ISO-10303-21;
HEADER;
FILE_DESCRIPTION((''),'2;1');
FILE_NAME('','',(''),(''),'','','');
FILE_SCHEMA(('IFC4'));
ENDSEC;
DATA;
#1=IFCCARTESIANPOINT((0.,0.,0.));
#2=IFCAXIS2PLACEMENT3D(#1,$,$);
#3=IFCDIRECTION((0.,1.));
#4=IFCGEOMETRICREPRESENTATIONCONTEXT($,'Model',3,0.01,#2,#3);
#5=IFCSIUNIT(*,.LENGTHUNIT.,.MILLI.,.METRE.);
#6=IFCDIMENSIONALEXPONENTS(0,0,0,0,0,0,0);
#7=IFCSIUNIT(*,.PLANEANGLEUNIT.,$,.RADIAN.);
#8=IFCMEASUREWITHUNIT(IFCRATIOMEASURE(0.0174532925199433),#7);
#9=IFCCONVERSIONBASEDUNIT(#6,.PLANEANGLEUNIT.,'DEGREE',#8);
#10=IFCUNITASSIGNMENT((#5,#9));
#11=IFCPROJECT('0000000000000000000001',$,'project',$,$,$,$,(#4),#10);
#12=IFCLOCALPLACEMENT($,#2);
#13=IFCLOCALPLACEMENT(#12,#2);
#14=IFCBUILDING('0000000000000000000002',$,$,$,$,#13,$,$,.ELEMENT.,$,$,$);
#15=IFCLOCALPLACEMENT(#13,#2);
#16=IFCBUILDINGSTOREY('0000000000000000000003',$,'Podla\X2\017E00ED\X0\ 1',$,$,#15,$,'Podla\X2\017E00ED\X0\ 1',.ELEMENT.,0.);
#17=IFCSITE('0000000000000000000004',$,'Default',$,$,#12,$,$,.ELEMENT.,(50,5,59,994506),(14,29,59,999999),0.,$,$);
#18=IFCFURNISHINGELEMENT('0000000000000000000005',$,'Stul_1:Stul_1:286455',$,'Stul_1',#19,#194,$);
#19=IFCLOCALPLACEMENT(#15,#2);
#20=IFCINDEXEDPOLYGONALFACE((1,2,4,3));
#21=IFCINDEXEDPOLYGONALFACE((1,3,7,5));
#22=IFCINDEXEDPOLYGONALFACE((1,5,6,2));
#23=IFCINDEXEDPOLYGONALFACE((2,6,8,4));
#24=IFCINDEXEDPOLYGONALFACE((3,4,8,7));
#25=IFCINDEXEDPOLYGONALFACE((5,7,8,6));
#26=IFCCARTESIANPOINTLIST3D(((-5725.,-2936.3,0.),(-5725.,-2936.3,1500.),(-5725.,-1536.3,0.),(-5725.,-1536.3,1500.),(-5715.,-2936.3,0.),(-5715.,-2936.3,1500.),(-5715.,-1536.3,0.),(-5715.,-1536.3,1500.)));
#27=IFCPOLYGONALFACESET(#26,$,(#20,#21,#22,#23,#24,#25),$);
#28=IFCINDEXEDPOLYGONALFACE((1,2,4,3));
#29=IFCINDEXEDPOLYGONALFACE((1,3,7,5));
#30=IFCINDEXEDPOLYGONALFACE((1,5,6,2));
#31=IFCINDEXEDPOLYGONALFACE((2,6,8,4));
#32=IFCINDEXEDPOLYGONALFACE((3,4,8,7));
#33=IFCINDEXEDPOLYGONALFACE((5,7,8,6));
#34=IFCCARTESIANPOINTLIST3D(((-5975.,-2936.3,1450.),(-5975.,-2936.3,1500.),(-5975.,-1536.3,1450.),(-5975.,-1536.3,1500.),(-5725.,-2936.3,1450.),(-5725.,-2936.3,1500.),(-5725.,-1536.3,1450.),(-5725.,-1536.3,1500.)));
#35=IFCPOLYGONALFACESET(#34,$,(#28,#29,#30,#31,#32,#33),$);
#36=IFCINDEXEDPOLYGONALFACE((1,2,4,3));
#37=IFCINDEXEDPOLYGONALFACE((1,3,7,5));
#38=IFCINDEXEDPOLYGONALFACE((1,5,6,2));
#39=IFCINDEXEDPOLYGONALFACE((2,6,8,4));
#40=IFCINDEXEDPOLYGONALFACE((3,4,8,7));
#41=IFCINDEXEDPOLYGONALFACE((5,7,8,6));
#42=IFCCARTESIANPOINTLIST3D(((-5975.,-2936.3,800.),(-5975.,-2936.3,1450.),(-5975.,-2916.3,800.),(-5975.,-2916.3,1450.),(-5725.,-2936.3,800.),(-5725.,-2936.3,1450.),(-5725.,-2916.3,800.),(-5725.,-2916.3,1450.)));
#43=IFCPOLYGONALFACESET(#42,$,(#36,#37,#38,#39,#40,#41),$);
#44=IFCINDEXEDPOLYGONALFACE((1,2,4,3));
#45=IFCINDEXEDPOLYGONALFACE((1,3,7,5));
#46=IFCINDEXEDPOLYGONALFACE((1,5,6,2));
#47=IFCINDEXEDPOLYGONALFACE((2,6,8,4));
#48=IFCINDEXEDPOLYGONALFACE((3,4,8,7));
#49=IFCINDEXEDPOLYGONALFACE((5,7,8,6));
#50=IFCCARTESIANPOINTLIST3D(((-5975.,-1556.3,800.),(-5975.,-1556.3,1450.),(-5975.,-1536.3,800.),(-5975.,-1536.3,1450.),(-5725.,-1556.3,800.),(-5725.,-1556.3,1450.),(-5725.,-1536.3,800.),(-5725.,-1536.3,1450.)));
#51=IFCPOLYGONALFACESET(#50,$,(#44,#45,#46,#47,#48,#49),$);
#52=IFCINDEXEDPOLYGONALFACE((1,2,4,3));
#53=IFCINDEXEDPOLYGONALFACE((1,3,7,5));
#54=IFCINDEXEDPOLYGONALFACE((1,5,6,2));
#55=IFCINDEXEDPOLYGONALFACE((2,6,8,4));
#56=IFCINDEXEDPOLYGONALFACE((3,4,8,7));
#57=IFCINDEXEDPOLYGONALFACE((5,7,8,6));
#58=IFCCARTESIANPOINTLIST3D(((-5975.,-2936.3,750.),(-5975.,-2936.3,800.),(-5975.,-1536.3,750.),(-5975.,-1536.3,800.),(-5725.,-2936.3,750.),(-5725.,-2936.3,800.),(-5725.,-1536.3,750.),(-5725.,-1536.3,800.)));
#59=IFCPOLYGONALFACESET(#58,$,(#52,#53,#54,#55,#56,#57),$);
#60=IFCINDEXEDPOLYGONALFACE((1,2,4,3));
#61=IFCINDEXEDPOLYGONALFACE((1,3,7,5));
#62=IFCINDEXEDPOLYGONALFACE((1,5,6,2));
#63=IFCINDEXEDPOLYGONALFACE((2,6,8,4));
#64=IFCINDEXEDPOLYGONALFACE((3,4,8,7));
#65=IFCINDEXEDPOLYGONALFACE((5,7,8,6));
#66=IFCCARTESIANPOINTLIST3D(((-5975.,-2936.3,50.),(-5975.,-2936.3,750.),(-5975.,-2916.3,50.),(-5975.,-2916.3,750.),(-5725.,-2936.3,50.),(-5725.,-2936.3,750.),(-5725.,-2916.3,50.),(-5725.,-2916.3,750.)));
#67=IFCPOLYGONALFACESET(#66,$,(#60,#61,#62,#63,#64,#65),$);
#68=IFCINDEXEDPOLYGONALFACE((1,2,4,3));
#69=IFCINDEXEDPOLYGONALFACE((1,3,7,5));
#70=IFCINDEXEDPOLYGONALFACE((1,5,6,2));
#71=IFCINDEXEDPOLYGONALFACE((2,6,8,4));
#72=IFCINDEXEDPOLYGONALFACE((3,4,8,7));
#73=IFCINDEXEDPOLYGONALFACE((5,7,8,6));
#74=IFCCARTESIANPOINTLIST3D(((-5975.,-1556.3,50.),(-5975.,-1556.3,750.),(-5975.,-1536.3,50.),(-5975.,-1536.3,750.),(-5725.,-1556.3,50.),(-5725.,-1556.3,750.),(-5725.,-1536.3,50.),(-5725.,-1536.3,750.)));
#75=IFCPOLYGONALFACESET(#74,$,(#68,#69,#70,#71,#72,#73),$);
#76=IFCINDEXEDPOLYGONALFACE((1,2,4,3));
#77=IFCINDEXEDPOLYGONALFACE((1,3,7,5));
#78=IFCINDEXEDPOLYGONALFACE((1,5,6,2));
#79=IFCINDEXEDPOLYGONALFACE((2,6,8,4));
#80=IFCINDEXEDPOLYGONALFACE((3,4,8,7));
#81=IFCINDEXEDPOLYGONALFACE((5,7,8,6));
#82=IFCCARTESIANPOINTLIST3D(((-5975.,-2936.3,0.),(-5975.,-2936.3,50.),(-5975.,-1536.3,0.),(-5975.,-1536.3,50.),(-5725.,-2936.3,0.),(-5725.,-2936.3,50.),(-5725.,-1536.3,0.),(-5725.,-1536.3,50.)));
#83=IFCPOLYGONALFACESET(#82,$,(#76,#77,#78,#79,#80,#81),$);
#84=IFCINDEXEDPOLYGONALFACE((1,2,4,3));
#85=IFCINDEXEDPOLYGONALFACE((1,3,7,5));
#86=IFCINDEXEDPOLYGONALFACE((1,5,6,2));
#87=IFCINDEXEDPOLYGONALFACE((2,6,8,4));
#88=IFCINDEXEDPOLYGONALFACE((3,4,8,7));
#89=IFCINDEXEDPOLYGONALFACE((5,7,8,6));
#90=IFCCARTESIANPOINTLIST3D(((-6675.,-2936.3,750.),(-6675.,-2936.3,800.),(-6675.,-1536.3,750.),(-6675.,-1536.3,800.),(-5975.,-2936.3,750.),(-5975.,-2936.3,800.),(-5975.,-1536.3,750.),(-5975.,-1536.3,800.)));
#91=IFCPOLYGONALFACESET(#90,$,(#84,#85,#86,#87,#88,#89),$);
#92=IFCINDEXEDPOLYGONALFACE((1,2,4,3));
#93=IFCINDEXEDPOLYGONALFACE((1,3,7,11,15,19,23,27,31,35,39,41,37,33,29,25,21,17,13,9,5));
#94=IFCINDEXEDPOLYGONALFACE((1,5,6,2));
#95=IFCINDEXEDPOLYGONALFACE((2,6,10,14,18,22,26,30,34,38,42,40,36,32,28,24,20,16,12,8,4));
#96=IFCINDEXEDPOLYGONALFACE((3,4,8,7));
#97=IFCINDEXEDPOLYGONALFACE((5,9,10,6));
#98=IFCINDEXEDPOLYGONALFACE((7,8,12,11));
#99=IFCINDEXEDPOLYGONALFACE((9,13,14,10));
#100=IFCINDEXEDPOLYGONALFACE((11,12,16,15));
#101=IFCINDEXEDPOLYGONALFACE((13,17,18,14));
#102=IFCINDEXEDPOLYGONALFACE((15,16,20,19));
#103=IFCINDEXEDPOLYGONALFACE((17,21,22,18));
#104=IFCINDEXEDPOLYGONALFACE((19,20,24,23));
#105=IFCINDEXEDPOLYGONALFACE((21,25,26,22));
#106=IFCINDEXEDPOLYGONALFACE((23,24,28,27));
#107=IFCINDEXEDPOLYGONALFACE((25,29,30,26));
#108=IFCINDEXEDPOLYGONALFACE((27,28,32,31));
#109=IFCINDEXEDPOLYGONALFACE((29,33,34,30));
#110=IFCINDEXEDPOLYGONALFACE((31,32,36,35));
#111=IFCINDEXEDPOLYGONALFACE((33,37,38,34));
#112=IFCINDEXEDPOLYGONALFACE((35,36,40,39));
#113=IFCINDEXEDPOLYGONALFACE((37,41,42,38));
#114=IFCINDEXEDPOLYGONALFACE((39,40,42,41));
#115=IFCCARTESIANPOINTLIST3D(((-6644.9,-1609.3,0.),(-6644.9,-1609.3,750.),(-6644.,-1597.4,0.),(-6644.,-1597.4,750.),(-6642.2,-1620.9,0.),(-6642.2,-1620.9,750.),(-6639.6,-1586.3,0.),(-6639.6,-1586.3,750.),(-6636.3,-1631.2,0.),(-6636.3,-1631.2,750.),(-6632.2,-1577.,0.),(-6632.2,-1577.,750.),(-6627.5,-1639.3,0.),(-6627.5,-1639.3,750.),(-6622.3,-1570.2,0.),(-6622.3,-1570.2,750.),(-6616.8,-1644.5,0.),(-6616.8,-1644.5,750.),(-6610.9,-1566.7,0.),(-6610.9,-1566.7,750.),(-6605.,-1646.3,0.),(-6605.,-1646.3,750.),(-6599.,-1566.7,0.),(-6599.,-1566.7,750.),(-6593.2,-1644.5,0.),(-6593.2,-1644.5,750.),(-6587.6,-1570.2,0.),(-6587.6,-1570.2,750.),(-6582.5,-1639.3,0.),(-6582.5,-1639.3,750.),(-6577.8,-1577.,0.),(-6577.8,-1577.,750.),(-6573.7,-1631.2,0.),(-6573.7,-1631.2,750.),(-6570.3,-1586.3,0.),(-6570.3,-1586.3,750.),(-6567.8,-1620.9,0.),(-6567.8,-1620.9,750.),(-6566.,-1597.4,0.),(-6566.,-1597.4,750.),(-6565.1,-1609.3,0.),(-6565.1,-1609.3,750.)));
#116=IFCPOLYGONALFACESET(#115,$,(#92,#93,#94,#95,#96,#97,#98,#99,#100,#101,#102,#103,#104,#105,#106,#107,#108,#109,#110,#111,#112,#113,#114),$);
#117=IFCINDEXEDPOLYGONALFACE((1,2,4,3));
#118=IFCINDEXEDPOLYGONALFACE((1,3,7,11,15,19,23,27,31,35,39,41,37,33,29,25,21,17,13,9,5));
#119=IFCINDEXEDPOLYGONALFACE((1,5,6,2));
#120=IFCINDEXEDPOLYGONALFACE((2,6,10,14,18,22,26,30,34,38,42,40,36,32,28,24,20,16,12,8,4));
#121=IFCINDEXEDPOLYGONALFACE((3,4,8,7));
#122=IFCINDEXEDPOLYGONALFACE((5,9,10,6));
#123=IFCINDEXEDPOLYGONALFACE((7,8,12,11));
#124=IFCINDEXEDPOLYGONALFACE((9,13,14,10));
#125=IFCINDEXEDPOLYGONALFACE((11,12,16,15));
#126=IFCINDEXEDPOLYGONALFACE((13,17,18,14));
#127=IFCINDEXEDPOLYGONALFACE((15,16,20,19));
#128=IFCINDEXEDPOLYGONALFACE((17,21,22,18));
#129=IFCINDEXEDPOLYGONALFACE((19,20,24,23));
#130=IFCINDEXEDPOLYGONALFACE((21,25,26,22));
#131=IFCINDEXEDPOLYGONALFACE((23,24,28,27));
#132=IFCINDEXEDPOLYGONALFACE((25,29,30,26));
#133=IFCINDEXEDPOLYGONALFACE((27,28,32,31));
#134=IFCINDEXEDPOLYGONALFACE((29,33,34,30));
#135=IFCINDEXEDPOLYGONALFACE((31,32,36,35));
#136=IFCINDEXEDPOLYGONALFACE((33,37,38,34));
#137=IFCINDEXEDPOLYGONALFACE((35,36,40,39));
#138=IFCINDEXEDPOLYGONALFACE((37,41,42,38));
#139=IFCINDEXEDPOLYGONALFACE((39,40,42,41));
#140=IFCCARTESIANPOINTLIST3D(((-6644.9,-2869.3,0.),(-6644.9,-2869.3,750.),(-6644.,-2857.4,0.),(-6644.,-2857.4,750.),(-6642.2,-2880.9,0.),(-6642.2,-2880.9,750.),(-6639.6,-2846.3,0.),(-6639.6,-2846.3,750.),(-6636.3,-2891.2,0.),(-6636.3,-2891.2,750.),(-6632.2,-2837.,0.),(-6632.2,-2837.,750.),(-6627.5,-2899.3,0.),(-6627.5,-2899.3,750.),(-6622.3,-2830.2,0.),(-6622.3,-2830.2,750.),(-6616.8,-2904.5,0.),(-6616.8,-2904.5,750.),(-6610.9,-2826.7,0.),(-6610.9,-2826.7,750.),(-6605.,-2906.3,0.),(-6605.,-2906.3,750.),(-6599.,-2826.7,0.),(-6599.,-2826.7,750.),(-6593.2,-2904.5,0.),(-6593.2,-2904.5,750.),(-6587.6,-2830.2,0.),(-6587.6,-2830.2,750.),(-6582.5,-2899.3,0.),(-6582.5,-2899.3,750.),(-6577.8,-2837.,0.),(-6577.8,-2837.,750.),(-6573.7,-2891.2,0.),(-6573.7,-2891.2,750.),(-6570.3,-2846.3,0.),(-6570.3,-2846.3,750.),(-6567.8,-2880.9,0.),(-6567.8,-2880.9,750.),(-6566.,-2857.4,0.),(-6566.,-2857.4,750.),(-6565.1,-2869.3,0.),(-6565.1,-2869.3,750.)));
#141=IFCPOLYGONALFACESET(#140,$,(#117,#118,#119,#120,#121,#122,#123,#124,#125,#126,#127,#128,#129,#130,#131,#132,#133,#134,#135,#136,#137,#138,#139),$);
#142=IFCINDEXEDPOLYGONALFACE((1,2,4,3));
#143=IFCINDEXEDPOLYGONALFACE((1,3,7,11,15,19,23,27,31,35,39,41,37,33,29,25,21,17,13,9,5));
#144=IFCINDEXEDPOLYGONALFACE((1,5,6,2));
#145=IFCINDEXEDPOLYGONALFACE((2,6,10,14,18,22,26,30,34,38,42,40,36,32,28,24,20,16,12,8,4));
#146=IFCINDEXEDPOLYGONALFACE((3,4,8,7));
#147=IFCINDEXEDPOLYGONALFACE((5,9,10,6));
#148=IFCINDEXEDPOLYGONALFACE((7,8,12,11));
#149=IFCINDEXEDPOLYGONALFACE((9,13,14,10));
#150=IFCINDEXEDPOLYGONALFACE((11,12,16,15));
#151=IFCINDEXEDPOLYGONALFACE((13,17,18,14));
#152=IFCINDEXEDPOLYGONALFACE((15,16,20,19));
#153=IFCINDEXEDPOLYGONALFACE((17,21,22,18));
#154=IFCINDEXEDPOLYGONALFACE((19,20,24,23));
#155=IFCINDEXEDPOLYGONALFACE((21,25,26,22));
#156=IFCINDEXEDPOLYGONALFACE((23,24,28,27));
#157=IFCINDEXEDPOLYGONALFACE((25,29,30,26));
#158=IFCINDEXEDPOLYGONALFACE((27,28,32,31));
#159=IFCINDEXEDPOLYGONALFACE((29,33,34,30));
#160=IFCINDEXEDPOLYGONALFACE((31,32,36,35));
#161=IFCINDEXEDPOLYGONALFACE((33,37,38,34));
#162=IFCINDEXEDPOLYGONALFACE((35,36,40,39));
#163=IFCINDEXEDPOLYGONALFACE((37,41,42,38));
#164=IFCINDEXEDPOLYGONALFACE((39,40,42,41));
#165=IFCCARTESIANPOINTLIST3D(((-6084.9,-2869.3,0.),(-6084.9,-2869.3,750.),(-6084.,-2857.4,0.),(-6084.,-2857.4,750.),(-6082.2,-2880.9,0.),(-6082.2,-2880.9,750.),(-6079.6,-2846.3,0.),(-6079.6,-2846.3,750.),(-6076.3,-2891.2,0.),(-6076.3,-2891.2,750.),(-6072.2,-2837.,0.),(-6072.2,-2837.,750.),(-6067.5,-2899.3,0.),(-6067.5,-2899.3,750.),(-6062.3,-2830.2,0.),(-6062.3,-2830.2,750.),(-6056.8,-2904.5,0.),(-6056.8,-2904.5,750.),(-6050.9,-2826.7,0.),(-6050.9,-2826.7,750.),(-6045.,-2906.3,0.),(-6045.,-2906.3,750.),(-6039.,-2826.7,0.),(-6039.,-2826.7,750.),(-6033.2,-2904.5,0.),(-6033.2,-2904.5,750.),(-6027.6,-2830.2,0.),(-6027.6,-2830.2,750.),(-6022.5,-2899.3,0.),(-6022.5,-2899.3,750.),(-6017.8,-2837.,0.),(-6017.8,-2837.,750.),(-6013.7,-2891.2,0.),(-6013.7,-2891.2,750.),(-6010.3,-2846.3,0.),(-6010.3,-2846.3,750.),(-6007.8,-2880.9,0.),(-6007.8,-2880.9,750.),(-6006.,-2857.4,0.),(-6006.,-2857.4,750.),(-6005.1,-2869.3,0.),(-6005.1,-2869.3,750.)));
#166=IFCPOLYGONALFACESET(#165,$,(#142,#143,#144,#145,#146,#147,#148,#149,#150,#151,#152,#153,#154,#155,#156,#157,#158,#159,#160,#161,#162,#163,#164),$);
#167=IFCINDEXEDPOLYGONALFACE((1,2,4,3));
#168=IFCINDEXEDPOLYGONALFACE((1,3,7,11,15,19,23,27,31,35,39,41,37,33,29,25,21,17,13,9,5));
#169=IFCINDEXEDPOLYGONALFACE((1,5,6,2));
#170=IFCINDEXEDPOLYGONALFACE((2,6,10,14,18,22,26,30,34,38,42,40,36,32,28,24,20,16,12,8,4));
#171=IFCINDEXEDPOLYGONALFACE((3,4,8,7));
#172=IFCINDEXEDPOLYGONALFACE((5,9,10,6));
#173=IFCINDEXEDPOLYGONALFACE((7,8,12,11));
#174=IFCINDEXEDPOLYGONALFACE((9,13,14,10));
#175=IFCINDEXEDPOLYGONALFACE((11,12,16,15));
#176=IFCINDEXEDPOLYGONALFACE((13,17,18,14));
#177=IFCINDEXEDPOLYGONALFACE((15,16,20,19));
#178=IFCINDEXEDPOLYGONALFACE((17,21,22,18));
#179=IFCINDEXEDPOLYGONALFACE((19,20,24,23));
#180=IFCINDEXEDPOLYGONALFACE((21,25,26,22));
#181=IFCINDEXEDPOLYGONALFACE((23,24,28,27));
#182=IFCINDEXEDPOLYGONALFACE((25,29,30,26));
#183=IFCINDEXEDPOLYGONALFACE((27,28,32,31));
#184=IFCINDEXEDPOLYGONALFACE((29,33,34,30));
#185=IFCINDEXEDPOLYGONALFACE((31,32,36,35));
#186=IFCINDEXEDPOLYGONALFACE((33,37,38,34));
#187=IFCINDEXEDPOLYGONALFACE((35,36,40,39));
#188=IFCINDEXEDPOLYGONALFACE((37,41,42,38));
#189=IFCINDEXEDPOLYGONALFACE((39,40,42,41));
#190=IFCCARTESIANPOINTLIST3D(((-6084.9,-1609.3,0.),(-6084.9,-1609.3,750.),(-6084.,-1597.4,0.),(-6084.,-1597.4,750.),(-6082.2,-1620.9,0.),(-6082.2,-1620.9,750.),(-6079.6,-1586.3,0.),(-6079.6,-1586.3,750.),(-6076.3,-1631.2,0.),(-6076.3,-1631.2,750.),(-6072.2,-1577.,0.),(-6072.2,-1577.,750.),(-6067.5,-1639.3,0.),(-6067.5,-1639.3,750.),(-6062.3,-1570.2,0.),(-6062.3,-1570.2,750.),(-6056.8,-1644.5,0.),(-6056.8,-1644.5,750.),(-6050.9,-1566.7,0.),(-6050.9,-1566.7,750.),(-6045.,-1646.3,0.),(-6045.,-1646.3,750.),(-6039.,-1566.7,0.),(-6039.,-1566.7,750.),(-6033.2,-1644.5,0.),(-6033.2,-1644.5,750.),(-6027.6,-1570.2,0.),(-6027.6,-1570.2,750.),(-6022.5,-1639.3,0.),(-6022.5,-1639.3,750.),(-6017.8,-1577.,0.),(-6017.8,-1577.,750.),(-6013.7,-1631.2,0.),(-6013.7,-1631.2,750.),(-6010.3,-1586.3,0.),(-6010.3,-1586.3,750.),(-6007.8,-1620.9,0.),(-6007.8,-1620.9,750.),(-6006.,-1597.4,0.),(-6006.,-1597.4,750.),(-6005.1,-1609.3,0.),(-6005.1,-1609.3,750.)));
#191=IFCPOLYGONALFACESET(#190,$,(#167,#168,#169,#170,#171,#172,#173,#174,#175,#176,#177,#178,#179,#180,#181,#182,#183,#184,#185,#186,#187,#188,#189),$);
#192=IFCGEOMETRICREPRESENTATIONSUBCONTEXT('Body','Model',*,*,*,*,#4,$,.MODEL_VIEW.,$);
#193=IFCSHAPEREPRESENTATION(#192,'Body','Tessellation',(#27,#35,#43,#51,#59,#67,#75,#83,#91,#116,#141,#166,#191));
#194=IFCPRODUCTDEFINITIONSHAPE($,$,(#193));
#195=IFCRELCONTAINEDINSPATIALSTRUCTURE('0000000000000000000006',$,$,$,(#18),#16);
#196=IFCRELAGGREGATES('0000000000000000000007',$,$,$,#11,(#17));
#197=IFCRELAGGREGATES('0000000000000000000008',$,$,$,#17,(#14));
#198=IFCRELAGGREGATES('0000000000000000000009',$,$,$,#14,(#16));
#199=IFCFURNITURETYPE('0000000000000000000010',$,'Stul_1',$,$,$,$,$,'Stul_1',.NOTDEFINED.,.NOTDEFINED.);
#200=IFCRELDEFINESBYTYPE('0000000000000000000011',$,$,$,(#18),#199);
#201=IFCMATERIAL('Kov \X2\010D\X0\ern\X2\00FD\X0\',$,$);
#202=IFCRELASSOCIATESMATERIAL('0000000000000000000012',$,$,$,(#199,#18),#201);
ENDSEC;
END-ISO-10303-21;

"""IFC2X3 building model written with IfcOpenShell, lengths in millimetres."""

from ifc_helpers import new_model, entity, si_unit, converted_unit, direction, frame, frame_2d, origin, origin_2d_with_axis, place, context, subcontext, project, spatial, rectangle, circle, extrude, source, transform, mapped, material, type_object, type_shapes, element, save


model = new_model("IFC2X3")

# Units and contexts
model_context = context("Model", 3, precision=0.01, world=origin(), true_north=direction((0.0, 1.0)))
body_context = subcontext(model_context, "Body", "Model", "MODEL_VIEW")
ifc_project = project(units=[si_unit("LENGTHUNIT", "METRE", prefix="MILLI"), converted_unit("PLANEANGLEUNIT", "DEGREE", entity("IfcRatioMeasure", 0.0174532925199433), si_unit("PLANEANGLEUNIT", "RADIAN"), dimensions=[0, 0, 0, 0, 0, 0, 0])], contexts=[model_context])

# Site, building, storey
site_placement = place(None, origin())
site = spatial("IfcSite", under=ifc_project, at=site_placement, Name="Default", CompositionType="ELEMENT", RefLatitude=(50, 5, 59, 994506), RefLongitude=(14, 29, 59, 999999), RefElevation=0.0)
building_placement = place(site_placement, origin())
building = spatial("IfcBuilding", under=site, at=building_placement, CompositionType="ELEMENT")
storey_placement = place(building_placement, origin())
storey = spatial("IfcBuildingStorey", under=building, at=storey_placement, Name="Podlaží 1", LongName="Podlaží 1", CompositionType="ELEMENT", Elevation=0.0)

# Furnishing element
ifc_material_1 = material(Name="Kov černý")
furniture_type = type_object("IfcFurnitureType", Name="Stul_1", ElementType="Stul_1", material=ifc_material_1)
shared_shape_1 = source(origin(), body_context, "Body", "SweptSolid", [
    extrude(rectangle(XDim=1400.0, YDim=10.0, at=origin_2d_with_axis()), frame((0.0, 605.0, 0.0), z_axis=(0.0, 0.0, 1.0), x_axis=(-1.0, 0.0, 0.0)), (0.0, 0.0, 1.0), 1500.0),
    extrude(rectangle(XDim=1400.0, YDim=250.0, at=frame_2d((0.0, 0.0), x_axis=(1.0, 0.0))), frame((0.0, 475.0, 1450.0), z_axis=(0.0, 0.0, 1.0), x_axis=(-1.0, 0.0, 0.0)), (0.0, 0.0, 1.0), 50.0),
    extrude(rectangle(XDim=20.0, YDim=250.0, at=origin_2d_with_axis()), frame((690.0, 475.0, 800.0), z_axis=(0.0, 0.0, 1.0), x_axis=(-1.0, 0.0, 0.0)), (0.0, 0.0, 1.0), 650.0),
    extrude(rectangle(XDim=20.0, YDim=250.0, at=frame_2d((0.0, 0.0), x_axis=(1.0, 0.0))), frame((-690.0, 475.0, 800.0), z_axis=(0.0, 0.0, 1.0), x_axis=(-1.0, 0.0, 0.0)), (0.0, 0.0, 1.0), 650.0),
    extrude(rectangle(XDim=1400.0, YDim=250.0, at=origin_2d_with_axis()), frame((0.0, 475.0, 750.0), z_axis=(0.0, 0.0, 1.0), x_axis=(-1.0, 0.0, 0.0)), (0.0, 0.0, 1.0), 50.0),
    extrude(rectangle(XDim=20.0, YDim=250.0, at=origin_2d_with_axis()), frame((690.0, 475.0, 50.0), z_axis=(0.0, 0.0, 1.0), x_axis=(-1.0, 0.0, 0.0)), (0.0, 0.0, 1.0), 700.0),
    extrude(rectangle(XDim=20.0, YDim=250.0, at=frame_2d((0.0, 0.0), x_axis=(1.0, 0.0))), frame((-690.0, 475.0, 50.0), z_axis=(0.0, 0.0, 1.0), x_axis=(-1.0, 0.0, 0.0)), (0.0, 0.0, 1.0), 700.0),
    extrude(rectangle(XDim=1400.0, YDim=250.0, at=origin_2d_with_axis()), frame((0.0, 475.0, 0.0), z_axis=(0.0, 0.0, 1.0), x_axis=(-1.0, 0.0, 0.0)), (0.0, 0.0, 1.0), 50.0),
    extrude(rectangle(XDim=1400.0, YDim=700.0, at=origin_2d_with_axis()), frame((0.0, 0.0, 750.0), z_axis=(0.0, 0.0, 1.0), x_axis=(-1.0, 0.0, 0.0)), (0.0, 0.0, 1.0), 50.0),
    extrude(circle(Radius=40.0, at=frame_2d((0.0, 0.0), x_axis=(1.0, 0.0))), frame((-630.0, -280.0, 0.0)), (0.0, 0.0, 1.0), 750.0),
    extrude(circle(Radius=40.0, at=frame_2d((0.0, 0.0), x_axis=(1.0, 0.0))), frame((630.0, -280.0, 0.0)), (0.0, 0.0, 1.0), 750.0),
    extrude(circle(Radius=40.0, at=frame_2d((0.0, 0.0), x_axis=(1.0, 0.0))), frame((630.0, 280.0, 0.0)), (0.0, 0.0, 1.0), 750.0),
    extrude(circle(Radius=40.0, at=frame_2d((0.0, 0.0), x_axis=(1.0, 0.0))), frame((-630.0, 280.0, 0.0)), (0.0, 0.0, 1.0), 750.0),
])
type_shapes(furniture_type, [shared_shape_1])
for number, where, z_axis, x_axis, name in (
    (1, (-6325.0, -2236.3, 0.0), (0.0, 0.0, 1.0), (0.0, -1.0, 0.0), "Stul_1:Stul_1:286455"),
):
    element("IfcFurnishingElement", number, at=place(storey_placement, frame(where, z_axis=z_axis, x_axis=x_axis)), inside=storey, type_object=furniture_type, material=ifc_material_1, Name=name, ObjectType="Stul_1", context=body_context, shape_type="MappedRepresentation", body=[
        mapped(shared_shape_1, transform((0.0, 0.0, 0.0), scale=1.0)),
    ])

save(model, "model.ifc")
